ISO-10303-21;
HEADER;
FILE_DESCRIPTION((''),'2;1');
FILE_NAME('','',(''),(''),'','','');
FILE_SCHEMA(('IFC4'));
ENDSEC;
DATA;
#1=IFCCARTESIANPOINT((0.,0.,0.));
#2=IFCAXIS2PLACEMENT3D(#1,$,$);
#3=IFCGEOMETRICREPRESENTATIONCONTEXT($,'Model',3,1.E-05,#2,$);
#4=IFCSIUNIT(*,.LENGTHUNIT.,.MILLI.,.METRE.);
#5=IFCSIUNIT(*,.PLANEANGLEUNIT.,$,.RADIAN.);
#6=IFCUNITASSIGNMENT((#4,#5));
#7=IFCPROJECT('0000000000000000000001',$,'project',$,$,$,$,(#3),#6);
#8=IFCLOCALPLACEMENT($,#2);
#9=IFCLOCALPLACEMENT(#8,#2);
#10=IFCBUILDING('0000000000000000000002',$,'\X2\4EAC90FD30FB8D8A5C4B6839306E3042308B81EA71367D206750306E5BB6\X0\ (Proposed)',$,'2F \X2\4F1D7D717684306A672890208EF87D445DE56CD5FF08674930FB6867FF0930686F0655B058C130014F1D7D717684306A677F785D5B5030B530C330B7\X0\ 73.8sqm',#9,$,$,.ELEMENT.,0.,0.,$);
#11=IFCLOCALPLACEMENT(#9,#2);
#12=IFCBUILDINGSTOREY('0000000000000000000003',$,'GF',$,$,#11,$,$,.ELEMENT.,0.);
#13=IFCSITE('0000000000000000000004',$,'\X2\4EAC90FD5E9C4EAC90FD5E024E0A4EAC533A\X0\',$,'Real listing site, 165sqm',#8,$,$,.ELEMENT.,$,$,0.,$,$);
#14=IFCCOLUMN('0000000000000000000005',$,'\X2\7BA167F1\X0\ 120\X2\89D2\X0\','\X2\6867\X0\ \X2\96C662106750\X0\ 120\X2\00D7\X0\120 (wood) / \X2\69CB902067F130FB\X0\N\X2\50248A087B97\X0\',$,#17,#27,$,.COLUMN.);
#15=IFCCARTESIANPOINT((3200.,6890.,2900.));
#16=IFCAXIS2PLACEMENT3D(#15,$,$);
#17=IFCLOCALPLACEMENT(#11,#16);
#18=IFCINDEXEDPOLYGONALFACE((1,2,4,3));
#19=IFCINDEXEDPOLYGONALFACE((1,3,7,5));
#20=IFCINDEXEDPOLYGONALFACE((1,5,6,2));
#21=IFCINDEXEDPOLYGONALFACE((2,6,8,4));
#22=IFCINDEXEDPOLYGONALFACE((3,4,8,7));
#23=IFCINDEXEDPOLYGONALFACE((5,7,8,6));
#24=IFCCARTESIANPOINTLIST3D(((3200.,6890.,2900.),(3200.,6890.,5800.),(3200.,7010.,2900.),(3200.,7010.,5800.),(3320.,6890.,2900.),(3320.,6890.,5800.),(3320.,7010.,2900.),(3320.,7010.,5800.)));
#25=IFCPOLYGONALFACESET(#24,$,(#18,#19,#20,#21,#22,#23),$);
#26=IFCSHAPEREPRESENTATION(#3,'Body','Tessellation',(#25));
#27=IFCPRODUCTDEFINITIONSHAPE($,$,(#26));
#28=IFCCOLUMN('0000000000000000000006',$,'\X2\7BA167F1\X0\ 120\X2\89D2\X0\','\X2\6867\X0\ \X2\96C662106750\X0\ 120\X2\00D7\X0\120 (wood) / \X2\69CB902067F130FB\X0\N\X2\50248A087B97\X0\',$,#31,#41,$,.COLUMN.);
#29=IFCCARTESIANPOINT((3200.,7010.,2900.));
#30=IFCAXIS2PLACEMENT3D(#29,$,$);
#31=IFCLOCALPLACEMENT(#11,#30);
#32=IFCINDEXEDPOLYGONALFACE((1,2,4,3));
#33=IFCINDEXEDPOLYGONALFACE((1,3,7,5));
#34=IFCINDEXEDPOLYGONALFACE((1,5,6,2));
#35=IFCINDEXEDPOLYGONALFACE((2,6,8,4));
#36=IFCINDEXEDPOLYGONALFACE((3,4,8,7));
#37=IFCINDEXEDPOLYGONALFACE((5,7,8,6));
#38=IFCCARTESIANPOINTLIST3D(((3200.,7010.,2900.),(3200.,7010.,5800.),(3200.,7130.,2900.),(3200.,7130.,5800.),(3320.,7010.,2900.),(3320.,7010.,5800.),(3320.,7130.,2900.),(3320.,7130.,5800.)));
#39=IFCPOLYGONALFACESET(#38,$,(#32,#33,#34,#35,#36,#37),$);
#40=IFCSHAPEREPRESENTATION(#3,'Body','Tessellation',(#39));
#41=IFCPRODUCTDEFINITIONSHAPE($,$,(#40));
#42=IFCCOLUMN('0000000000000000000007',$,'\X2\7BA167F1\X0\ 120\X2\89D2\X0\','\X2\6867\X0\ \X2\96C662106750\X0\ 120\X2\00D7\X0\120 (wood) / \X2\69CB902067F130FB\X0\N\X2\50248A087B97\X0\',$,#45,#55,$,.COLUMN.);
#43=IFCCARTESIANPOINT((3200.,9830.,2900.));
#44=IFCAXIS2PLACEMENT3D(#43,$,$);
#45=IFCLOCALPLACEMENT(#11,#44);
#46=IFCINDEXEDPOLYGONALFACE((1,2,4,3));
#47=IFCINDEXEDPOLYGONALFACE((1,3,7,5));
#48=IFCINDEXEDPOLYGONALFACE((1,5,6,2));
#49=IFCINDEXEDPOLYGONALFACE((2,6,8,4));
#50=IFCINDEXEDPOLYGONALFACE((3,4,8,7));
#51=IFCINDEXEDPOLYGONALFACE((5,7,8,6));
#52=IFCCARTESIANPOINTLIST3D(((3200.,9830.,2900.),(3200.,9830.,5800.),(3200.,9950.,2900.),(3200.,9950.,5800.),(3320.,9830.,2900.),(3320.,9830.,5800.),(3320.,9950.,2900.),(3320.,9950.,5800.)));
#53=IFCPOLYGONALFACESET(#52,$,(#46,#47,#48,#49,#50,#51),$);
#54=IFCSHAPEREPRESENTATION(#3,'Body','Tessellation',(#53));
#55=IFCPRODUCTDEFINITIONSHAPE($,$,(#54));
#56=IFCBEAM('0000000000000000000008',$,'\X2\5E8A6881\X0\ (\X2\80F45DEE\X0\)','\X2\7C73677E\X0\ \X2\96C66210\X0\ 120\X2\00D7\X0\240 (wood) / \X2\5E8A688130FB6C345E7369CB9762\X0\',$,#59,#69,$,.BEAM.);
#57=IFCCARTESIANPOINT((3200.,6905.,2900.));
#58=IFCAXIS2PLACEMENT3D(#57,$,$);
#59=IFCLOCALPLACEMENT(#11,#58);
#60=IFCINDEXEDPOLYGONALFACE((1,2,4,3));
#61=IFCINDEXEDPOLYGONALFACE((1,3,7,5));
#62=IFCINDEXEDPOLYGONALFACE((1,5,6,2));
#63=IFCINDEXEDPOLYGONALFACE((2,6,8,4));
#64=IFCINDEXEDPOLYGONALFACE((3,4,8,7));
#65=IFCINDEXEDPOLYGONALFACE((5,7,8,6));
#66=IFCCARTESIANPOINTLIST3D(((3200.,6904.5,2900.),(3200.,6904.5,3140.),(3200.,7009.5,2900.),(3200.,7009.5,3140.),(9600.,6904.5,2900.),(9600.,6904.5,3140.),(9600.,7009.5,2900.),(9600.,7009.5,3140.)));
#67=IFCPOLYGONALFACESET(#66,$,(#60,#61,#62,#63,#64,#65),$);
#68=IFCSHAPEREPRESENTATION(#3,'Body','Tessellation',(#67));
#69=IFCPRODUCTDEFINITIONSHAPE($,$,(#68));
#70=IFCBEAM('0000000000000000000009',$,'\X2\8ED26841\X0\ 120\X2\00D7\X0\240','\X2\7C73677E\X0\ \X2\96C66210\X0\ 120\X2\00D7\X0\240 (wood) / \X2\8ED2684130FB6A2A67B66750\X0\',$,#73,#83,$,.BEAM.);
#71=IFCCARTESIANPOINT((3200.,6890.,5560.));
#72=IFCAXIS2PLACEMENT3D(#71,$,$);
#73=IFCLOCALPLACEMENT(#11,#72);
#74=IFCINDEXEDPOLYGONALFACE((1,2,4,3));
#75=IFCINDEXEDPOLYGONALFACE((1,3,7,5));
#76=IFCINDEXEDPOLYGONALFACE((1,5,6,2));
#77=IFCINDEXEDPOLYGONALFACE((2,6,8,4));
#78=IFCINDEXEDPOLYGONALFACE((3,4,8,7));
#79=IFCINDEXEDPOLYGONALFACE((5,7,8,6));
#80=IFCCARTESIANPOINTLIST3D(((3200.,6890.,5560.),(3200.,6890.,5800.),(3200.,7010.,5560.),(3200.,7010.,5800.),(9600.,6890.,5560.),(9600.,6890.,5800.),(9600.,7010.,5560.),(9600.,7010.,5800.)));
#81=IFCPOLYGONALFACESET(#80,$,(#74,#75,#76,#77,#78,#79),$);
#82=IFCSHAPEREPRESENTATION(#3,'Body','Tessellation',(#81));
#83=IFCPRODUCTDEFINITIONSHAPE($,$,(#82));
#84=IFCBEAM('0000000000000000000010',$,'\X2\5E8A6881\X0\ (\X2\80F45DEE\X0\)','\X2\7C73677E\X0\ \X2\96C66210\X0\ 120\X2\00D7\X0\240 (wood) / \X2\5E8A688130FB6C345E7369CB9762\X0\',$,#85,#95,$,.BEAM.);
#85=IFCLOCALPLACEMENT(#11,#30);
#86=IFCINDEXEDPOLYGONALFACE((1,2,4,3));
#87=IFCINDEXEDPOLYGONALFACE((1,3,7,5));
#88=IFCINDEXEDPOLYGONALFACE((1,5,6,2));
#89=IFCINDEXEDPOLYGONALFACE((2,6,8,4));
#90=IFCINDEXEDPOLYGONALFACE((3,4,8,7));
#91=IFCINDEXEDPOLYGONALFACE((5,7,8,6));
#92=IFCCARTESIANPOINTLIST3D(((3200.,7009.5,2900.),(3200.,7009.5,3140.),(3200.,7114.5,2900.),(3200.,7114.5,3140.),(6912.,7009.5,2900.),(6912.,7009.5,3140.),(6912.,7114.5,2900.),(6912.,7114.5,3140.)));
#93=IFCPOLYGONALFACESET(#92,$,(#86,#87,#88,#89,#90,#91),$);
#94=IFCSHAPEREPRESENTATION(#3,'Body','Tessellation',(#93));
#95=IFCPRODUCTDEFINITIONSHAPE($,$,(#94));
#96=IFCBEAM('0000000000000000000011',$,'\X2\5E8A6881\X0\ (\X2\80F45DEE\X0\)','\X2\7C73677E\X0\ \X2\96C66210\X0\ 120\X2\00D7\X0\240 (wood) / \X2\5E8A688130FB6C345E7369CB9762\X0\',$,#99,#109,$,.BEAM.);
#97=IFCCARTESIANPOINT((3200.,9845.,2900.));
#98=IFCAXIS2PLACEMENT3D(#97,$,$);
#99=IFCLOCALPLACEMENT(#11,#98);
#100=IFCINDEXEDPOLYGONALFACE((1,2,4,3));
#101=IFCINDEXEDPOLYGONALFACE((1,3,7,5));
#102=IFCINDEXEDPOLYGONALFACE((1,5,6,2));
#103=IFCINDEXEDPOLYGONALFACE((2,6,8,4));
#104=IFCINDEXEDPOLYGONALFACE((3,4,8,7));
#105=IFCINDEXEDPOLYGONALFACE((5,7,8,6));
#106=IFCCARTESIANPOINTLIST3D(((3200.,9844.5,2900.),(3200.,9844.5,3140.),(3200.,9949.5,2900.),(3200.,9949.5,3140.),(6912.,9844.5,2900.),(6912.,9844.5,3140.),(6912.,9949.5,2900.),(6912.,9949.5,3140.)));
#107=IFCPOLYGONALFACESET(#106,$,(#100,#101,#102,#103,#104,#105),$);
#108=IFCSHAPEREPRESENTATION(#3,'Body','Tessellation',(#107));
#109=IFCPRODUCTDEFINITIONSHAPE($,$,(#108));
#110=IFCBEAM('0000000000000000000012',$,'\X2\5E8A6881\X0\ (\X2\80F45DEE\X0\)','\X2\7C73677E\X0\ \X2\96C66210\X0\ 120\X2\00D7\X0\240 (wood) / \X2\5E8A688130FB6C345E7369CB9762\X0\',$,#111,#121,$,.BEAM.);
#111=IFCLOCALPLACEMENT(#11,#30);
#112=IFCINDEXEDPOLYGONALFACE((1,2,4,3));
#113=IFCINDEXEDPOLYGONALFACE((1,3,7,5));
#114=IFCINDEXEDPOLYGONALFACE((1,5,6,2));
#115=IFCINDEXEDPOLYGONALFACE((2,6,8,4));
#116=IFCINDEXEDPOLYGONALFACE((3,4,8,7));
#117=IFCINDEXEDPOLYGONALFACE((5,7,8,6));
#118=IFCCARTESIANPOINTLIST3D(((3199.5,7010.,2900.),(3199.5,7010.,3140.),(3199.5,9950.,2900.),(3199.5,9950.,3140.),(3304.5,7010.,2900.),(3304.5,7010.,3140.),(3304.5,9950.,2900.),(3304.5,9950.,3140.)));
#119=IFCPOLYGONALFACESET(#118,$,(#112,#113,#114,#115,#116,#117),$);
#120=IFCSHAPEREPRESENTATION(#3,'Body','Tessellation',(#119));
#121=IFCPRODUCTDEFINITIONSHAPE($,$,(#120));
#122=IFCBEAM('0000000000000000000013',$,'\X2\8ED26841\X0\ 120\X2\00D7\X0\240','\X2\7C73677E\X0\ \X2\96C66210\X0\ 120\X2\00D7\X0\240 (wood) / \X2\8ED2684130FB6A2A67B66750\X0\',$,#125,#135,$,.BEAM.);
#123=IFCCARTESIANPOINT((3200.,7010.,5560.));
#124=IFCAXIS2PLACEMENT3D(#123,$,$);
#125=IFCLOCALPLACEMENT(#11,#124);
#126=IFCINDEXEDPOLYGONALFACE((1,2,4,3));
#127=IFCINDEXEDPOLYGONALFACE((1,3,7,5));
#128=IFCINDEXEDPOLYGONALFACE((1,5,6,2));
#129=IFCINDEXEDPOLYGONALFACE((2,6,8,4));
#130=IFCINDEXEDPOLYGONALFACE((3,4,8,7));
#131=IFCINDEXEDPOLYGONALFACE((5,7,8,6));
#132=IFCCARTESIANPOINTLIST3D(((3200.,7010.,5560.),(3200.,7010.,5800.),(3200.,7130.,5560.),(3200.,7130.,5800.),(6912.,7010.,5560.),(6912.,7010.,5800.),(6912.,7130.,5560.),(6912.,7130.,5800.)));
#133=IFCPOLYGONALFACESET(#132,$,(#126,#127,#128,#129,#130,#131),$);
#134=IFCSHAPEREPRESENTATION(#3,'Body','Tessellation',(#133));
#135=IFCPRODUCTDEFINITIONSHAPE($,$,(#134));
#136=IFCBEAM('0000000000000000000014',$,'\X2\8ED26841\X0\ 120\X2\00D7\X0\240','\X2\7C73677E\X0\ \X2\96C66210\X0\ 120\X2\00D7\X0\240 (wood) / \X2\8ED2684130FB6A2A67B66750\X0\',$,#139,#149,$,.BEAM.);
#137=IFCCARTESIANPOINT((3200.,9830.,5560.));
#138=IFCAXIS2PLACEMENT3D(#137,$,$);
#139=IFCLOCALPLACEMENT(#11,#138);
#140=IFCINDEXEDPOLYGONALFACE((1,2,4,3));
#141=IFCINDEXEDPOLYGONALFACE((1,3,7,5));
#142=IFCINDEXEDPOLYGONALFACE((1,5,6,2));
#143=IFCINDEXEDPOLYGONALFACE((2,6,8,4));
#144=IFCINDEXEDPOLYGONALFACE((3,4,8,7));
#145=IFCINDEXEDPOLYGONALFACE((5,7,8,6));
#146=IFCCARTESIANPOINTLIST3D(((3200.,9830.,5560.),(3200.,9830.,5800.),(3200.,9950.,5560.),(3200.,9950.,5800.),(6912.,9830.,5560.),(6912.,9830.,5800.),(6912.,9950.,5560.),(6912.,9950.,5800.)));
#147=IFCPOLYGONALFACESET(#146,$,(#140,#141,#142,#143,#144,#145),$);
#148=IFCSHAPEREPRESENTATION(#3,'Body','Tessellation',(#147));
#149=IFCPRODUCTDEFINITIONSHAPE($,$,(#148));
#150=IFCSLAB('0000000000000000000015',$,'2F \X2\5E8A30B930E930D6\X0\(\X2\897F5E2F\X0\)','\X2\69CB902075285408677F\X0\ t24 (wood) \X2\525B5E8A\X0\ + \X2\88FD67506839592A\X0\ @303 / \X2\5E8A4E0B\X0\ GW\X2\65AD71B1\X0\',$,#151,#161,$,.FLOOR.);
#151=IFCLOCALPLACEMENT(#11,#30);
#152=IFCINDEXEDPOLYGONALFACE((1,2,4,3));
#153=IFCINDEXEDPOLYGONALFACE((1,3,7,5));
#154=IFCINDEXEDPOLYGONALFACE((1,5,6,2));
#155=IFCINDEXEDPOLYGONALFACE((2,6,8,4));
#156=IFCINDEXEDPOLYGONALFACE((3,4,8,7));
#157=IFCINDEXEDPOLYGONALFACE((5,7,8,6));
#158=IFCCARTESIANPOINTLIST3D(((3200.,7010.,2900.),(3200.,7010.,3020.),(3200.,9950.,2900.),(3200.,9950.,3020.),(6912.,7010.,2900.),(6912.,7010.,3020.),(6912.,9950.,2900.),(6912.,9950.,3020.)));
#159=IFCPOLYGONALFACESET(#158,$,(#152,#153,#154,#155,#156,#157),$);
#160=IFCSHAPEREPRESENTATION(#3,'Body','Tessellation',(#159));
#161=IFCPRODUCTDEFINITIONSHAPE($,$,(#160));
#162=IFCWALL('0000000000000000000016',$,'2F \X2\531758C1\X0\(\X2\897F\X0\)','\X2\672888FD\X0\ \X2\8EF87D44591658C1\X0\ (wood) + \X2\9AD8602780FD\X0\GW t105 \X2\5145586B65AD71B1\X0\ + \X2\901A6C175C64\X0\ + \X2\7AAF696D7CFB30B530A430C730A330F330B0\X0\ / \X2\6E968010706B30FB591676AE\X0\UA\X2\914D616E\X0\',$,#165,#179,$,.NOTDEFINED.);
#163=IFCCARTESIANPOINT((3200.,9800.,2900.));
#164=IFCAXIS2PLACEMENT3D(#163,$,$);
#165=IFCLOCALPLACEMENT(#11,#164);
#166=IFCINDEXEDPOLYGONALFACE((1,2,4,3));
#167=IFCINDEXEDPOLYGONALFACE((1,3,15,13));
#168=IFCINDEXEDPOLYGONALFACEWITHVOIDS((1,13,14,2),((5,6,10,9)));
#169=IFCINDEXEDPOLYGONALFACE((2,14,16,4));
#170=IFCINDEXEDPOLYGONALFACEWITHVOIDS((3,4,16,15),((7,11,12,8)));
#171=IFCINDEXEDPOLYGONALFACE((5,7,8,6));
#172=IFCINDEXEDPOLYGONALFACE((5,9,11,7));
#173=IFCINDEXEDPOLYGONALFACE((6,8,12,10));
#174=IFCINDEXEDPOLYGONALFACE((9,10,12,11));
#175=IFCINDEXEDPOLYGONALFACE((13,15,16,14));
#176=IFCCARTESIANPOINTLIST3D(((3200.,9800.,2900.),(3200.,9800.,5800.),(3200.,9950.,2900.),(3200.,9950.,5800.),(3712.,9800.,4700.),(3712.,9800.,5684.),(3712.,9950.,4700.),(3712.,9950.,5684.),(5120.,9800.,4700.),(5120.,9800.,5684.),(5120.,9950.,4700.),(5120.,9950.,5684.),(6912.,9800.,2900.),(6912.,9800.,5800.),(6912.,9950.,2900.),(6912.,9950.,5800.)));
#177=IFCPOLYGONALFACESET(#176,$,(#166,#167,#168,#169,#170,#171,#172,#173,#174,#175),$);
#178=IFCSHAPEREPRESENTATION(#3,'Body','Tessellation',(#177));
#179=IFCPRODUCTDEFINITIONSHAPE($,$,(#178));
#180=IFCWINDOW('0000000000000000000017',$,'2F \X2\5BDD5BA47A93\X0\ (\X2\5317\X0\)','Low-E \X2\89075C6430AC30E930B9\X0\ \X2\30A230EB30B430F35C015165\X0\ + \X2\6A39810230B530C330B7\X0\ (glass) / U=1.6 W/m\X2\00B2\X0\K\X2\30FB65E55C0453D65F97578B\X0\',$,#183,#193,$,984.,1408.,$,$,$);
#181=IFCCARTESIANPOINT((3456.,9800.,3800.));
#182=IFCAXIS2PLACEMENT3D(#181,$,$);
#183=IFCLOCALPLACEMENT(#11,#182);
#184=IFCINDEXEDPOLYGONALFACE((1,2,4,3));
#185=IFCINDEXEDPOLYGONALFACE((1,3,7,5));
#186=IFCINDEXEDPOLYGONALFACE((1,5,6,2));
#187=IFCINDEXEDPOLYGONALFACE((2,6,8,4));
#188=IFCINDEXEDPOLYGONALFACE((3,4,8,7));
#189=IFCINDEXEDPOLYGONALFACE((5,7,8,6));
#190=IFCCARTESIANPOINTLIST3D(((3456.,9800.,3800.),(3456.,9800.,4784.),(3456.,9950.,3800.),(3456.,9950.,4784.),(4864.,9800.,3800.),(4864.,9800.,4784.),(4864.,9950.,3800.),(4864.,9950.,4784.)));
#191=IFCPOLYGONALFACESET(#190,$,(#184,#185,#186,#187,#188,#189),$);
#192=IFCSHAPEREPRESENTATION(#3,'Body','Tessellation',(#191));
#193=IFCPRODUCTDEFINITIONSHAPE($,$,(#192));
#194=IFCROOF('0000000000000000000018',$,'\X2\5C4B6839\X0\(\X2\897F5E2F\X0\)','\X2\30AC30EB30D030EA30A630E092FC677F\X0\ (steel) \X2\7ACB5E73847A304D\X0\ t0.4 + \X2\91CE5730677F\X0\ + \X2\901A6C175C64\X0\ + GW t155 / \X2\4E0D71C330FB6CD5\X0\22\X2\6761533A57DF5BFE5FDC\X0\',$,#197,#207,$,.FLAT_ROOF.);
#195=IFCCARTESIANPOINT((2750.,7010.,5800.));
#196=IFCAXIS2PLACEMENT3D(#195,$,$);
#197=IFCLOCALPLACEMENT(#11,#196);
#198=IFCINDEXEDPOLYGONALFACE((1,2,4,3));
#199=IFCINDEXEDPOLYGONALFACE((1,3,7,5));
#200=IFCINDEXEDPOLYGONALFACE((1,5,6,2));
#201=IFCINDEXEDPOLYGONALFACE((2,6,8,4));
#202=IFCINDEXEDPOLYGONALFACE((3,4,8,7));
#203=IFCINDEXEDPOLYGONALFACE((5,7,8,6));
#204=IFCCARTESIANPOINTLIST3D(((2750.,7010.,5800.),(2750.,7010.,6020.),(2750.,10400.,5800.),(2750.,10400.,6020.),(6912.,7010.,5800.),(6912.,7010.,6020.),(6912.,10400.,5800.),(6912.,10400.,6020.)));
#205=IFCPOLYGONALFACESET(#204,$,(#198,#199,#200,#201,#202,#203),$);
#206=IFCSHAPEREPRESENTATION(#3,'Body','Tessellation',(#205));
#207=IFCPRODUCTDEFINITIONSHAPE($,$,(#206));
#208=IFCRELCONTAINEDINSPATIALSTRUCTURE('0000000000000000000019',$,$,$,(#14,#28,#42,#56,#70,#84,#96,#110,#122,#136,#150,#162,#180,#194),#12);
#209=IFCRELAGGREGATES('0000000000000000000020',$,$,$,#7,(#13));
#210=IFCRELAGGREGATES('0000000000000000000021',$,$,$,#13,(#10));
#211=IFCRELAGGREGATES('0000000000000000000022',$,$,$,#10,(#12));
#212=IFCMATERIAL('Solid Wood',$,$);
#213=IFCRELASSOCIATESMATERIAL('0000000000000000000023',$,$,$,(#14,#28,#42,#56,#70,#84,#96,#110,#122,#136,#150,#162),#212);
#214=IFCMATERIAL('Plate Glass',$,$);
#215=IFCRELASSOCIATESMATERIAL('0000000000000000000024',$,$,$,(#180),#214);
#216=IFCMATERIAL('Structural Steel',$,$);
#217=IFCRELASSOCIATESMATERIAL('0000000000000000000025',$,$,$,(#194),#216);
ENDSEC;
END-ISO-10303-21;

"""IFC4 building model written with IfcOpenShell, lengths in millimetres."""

from ifc_helpers import new_model, si_unit, frame, frame_2d, origin, place, context, project, spatial, rectangle, extrude, material, element, fill, save


model = new_model("IFC4")

# Units and contexts
model_context = context("Model", 3, precision=1e-05, world=origin())
ifc_project = project(units=[si_unit("LENGTHUNIT", "METRE", prefix="MILLI"), si_unit("PLANEANGLEUNIT", "RADIAN")], contexts=[model_context])

# Site, building, storey
site_placement = place(None, origin())
site = spatial("IfcSite", under=ifc_project, at=site_placement, Name="京都府京都市上京区", ObjectType="Real listing site, 165sqm", CompositionType="ELEMENT", RefElevation=0.0)
building_placement = place(site_placement, origin())
building = spatial("IfcBuilding", under=site, at=building_placement, Name="京都・越屋根のある自然素材の家 (Proposed)", ObjectType="2F 伝統的な木造軸組工法（杉・桧）と漆喰壁、伝統的な板硝子サッシ 73.8sqm", CompositionType="ELEMENT", ElevationOfRefHeight=0.0, ElevationOfTerrain=0.0)
storey_placement = place(building_placement, origin())
storey = spatial("IfcBuildingStorey", under=building, at=storey_placement, Name="GF", CompositionType="ELEMENT", Elevation=0.0)

# Columns
ifc_material_1 = material(Name="Solid Wood")
column_1_placement = place(storey_placement, frame((3200.0, 6890.0, 2900.0)))
element("IfcColumn", 1, at=column_1_placement, inside=storey, material=ifc_material_1, Name="管柱 120角", Description="桧 集成材 120×120 (wood) / 構造柱・N値計算", PredefinedType="COLUMN", context=model_context, shape_type="SweptSolid", body=[
    extrude(rectangle(XDim=120.0, YDim=120.0, at=frame_2d((60.0, 60.0))), frame((3200.0, 6890.0, 2900.0)), (0.0, 0.0, 1.0), 2900.0),
])
column_2_placement = place(storey_placement, frame((3200.0, 7010.0, 2900.0)))
element("IfcColumn", 2, at=column_2_placement, inside=storey, material=ifc_material_1, Name="管柱 120角", Description="桧 集成材 120×120 (wood) / 構造柱・N値計算", PredefinedType="COLUMN", context=model_context, shape_type="SweptSolid", body=[
    extrude(rectangle(XDim=120.0, YDim=120.0, at=frame_2d((60.0, 60.0))), frame((3200.0, 7010.0, 2900.0)), (0.0, 0.0, 1.0), 2900.0),
])
column_3_placement = place(storey_placement, frame((3200.0, 9830.0, 2900.0)))
element("IfcColumn", 3, at=column_3_placement, inside=storey, material=ifc_material_1, Name="管柱 120角", Description="桧 集成材 120×120 (wood) / 構造柱・N値計算", PredefinedType="COLUMN", context=model_context, shape_type="SweptSolid", body=[
    extrude(rectangle(XDim=120.0, YDim=120.0, at=frame_2d((60.0, 60.0))), frame((3200.0, 9830.0, 2900.0)), (0.0, 0.0, 1.0), 2900.0),
])

# Beams
beam_1_placement = place(storey_placement, frame((3200.0, 6905.0, 2900.0)))
element("IfcBeam", 4, at=beam_1_placement, inside=storey, material=ifc_material_1, Name="床梁 (胴差)", Description="米松 集成 120×240 (wood) / 床梁・水平構面", PredefinedType="BEAM", context=model_context, shape_type="SweptSolid", body=[
    extrude(rectangle(XDim=6400.0, YDim=105.0, at=frame_2d((3200.0, 52.0))), frame((3200.0, 6905.0, 2900.0)), (0.0, 0.0, 1.0), 240.0),
])
beam_2_placement = place(storey_placement, frame((3200.0, 6890.0, 5560.0)))
element("IfcBeam", 5, at=beam_2_placement, inside=storey, material=ifc_material_1, Name="軒桁 120×240", Description="米松 集成 120×240 (wood) / 軒桁・横架材", PredefinedType="BEAM", context=model_context, shape_type="SweptSolid", body=[
    extrude(rectangle(XDim=6400.0, YDim=120.0, at=frame_2d((3200.0, 60.0))), frame((3200.0, 6890.0, 5560.0)), (0.0, 0.0, 1.0), 240.0),
])
beam_3_placement = place(storey_placement, frame((3200.0, 7010.0, 2900.0)))
element("IfcBeam", 6, at=beam_3_placement, inside=storey, material=ifc_material_1, Name="床梁 (胴差)", Description="米松 集成 120×240 (wood) / 床梁・水平構面", PredefinedType="BEAM", context=model_context, shape_type="SweptSolid", body=[
    extrude(rectangle(XDim=3712.0, YDim=105.0, at=frame_2d((1856.0, 52.0))), frame((3200.0, 7010.0, 2900.0)), (0.0, 0.0, 1.0), 240.0),
])
beam_4_placement = place(storey_placement, frame((3200.0, 9845.0, 2900.0)))
element("IfcBeam", 7, at=beam_4_placement, inside=storey, material=ifc_material_1, Name="床梁 (胴差)", Description="米松 集成 120×240 (wood) / 床梁・水平構面", PredefinedType="BEAM", context=model_context, shape_type="SweptSolid", body=[
    extrude(rectangle(XDim=3712.0, YDim=105.0, at=frame_2d((1856.0, 52.0))), frame((3200.0, 9845.0, 2900.0)), (0.0, 0.0, 1.0), 240.0),
])
beam_5_placement = place(storey_placement, frame((3200.0, 7010.0, 2900.0)))
element("IfcBeam", 8, at=beam_5_placement, inside=storey, material=ifc_material_1, Name="床梁 (胴差)", Description="米松 集成 120×240 (wood) / 床梁・水平構面", PredefinedType="BEAM", context=model_context, shape_type="SweptSolid", body=[
    extrude(rectangle(XDim=105.0, YDim=2940.0, at=frame_2d((52.0, 1470.0))), frame((3200.0, 7010.0, 2900.0)), (0.0, 0.0, 1.0), 240.0),
])
beam_6_placement = place(storey_placement, frame((3200.0, 7010.0, 5560.0)))
element("IfcBeam", 9, at=beam_6_placement, inside=storey, material=ifc_material_1, Name="軒桁 120×240", Description="米松 集成 120×240 (wood) / 軒桁・横架材", PredefinedType="BEAM", context=model_context, shape_type="SweptSolid", body=[
    extrude(rectangle(XDim=3712.0, YDim=120.0, at=frame_2d((1856.0, 60.0))), frame((3200.0, 7010.0, 5560.0)), (0.0, 0.0, 1.0), 240.0),
])
beam_7_placement = place(storey_placement, frame((3200.0, 9830.0, 5560.0)))
element("IfcBeam", 10, at=beam_7_placement, inside=storey, material=ifc_material_1, Name="軒桁 120×240", Description="米松 集成 120×240 (wood) / 軒桁・横架材", PredefinedType="BEAM", context=model_context, shape_type="SweptSolid", body=[
    extrude(rectangle(XDim=3712.0, YDim=120.0, at=frame_2d((1856.0, 60.0))), frame((3200.0, 9830.0, 5560.0)), (0.0, 0.0, 1.0), 240.0),
])

# Slab
slab_placement = place(storey_placement, frame((3200.0, 7010.0, 2900.0)))
element("IfcSlab", 11, at=slab_placement, inside=storey, material=ifc_material_1, Name="2F 床スラブ(西帯)", Description="構造用合板 t24 (wood) 剛床 + 製材根太 @303 / 床下 GW断熱", PredefinedType="FLOOR", context=model_context, shape_type="SweptSolid", body=[
    extrude(rectangle(XDim=3712.0, YDim=2940.0, at=frame_2d((1856.0, 1470.0))), frame((3200.0, 7010.0, 2900.0)), (0.0, 0.0, 1.0), 120.0),
])

# Wall, opening, window
wall_1_placement = place(storey_placement, frame((3200.0, 9800.0, 2900.0)))
wall_1 = element("IfcWall", 12, at=wall_1_placement, inside=storey, material=ifc_material_1, Name="2F 北壁(西)", Description="木製 軸組外壁 (wood) + 高性能GW t105 充填断熱 + 通気層 + 窯業系サイディング / 準耐火・外皮UA配慮", PredefinedType="NOTDEFINED", context=model_context, shape_type="SweptSolid", body=[
    extrude(rectangle(XDim=3712.0, YDim=150.0, at=frame_2d((1856.0, 75.0))), frame((3200.0, 9800.0, 2900.0)), (0.0, 0.0, 1.0), 2900.0),
])
opening_placement = place(storey_placement, frame((3456.0, 9800.0, 3800.0)))
opening = element("IfcOpeningElement", 13, at=opening_placement, cuts=wall_1, PredefinedType="NOTDEFINED", context=model_context, shape_type="SweptSolid", body=[
    extrude(rectangle(XDim=1408.0, YDim=150.0, at=frame_2d((704.0, 75.0))), frame((3456.0, 9800.0, 3800.0)), (0.0, 0.0, 1.0), 984.0),
])
ifc_material_2 = material(Name="Plate Glass")
window_placement = place(storey_placement, frame((3456.0, 9800.0, 3800.0)))
window = element("IfcWindow", 14, at=window_placement, inside=storey, material=ifc_material_2, Name="2F 寝室窓 (北)", Description="Low-E 複層ガラス アルゴン封入 + 樹脂サッシ (glass) / U=1.6 W/m²K・日射取得型", OverallHeight=984.0, OverallWidth=1408.0, context=model_context, shape_type="SweptSolid", body=[
    extrude(rectangle(XDim=1408.0, YDim=150.0, at=frame_2d((704.0, 75.0))), frame((3456.0, 9800.0, 3800.0)), (0.0, 0.0, 1.0), 984.0),
])
fill(opening, window)

# Roof
ifc_material_3 = material(Name="Structural Steel")
for number, where, name in (
    (15, (2750.0, 7010.0, 5800.0), "屋根(西帯)"),
):
    element("IfcRoof", number, at=place(storey_placement, frame(where)), inside=storey, material=ifc_material_3, Name=name, Description="ガルバリウム鋼板 (steel) 立平葺き t0.4 + 野地板 + 通気層 + GW t155 / 不燃・法22条区域対応", PredefinedType="FLAT_ROOF", context=model_context, shape_type="SweptSolid", body=[
        extrude(rectangle(XDim=4162.0, YDim=3390.0, at=frame_2d((2081.0, 1695.0))), frame((2750.0, 7010.0, 5800.0)), (0.0, 0.0, 1.0), 220.0),
    ])

save(model, "model.ifc")
